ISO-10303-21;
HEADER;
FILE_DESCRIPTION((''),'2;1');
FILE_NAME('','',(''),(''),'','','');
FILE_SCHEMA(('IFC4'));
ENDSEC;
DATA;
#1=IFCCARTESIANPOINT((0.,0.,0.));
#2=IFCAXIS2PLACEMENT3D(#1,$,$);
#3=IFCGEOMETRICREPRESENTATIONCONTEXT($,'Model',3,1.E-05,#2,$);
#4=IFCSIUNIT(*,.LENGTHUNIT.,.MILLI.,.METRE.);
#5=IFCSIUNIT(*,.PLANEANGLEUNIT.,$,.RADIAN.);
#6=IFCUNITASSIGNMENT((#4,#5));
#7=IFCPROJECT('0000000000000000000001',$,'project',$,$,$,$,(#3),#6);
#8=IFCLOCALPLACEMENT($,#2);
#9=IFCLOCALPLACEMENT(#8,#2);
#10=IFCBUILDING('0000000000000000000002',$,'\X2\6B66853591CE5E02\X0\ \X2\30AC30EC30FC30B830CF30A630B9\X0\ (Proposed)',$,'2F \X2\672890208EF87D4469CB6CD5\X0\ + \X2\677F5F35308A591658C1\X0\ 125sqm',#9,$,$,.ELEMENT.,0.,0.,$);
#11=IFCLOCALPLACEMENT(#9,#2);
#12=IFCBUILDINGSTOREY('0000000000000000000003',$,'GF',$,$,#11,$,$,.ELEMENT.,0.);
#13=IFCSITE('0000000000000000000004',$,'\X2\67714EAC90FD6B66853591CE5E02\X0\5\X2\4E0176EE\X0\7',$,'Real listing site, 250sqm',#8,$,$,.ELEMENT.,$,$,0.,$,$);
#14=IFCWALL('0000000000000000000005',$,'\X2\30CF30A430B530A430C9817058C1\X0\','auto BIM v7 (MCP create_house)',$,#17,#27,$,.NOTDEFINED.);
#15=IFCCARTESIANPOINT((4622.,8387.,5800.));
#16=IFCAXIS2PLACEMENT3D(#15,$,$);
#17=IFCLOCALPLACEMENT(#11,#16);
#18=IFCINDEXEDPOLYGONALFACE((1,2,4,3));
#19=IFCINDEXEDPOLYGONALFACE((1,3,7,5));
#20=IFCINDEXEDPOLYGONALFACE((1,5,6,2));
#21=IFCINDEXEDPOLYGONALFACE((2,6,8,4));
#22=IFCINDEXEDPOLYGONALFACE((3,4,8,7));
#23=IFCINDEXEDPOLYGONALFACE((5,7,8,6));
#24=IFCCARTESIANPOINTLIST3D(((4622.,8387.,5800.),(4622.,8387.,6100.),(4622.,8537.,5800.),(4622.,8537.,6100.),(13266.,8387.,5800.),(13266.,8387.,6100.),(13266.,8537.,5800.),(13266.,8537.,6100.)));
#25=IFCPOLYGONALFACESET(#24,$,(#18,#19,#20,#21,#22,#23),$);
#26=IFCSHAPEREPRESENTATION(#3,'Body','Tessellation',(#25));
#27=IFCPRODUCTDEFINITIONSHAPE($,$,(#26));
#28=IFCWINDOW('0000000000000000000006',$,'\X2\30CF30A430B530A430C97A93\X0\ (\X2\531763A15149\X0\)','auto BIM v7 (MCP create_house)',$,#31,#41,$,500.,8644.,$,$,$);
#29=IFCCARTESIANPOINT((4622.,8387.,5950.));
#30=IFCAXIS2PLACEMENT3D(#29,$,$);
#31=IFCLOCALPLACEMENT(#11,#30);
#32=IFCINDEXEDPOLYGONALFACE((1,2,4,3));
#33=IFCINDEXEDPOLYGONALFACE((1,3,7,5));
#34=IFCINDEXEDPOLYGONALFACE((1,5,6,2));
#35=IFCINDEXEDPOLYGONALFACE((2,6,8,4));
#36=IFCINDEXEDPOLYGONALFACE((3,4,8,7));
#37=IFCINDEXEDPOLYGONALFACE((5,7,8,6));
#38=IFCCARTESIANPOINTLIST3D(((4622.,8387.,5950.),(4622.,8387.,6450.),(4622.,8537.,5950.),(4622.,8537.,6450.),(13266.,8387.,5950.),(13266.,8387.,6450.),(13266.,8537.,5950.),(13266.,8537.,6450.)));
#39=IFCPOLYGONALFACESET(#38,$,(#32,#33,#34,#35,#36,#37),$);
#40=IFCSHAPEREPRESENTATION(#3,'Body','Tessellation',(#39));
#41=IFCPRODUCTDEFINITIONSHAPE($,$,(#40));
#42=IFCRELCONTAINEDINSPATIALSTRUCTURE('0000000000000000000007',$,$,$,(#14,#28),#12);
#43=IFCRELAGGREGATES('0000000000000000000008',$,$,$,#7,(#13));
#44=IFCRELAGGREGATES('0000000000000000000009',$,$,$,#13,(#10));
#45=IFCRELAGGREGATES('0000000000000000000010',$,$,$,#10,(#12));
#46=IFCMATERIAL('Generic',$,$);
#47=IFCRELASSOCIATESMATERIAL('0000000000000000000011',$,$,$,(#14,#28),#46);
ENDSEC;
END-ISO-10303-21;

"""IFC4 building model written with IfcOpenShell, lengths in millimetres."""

from ifc_helpers import new_model, si_unit, frame, frame_2d, origin, place, context, project, spatial, rectangle, extrude, material, element, fill, save


model = new_model("IFC4")

# Units and contexts
model_context = context("Model", 3, precision=1e-05, world=origin())
ifc_project = project(units=[si_unit("LENGTHUNIT", "METRE", prefix="MILLI"), si_unit("PLANEANGLEUNIT", "RADIAN")], contexts=[model_context])

# Site, building, storey
site_placement = place(None, origin())
site = spatial("IfcSite", under=ifc_project, at=site_placement, Name="東京都武蔵野市5丁目7", ObjectType="Real listing site, 250sqm", CompositionType="ELEMENT", RefElevation=0.0)
building_placement = place(site_placement, origin())
building = spatial("IfcBuilding", under=site, at=building_placement, Name="武蔵野市 ガレージハウス (Proposed)", ObjectType="2F 木造軸組構法 + 板張り外壁 125sqm", CompositionType="ELEMENT", ElevationOfRefHeight=0.0, ElevationOfTerrain=0.0)
storey_placement = place(building_placement, origin())
storey = spatial("IfcBuildingStorey", under=building, at=storey_placement, Name="GF", CompositionType="ELEMENT", Elevation=0.0)

# Shared definitions
ifc_material = material(Name="Generic")

# Wall, opening, window
wall_1_placement = place(storey_placement, frame((4622.0, 8387.0, 5800.0)))
wall_1 = element("IfcWall", 1, at=wall_1_placement, inside=storey, material=ifc_material, Name="ハイサイド腰壁", Description="auto BIM v7 (MCP create_house)", PredefinedType="NOTDEFINED", context=model_context, shape_type="SweptSolid", body=[
    extrude(rectangle(XDim=8644.0, YDim=150.0, at=frame_2d((4322.0, 75.0))), frame((4622.0, 8387.0, 5800.0)), (0.0, 0.0, 1.0), 700.0),
])
opening_1_placement = place(storey_placement, frame((4622.0, 8387.0, 5950.0)))
opening_1 = element("IfcOpeningElement", 2, at=opening_1_placement, cuts=wall_1, PredefinedType="NOTDEFINED", context=model_context, shape_type="SweptSolid", body=[
    extrude(rectangle(XDim=8644.0, YDim=150.0, at=frame_2d((4322.0, 75.0))), frame((4622.0, 8387.0, 5950.0)), (0.0, 0.0, 1.0), 500.0),
])
window_1_placement = place(storey_placement, frame((4622.0, 8387.0, 5950.0)))
window_1 = element("IfcWindow", 3, at=window_1_placement, inside=storey, material=ifc_material, Name="ハイサイド窓 (北採光)", Description="auto BIM v7 (MCP create_house)", OverallHeight=500.0, OverallWidth=8644.0, context=model_context, shape_type="SweptSolid", body=[
    extrude(rectangle(XDim=8644.0, YDim=150.0, at=frame_2d((4322.0, 75.0))), frame((4622.0, 8387.0, 5950.0)), (0.0, 0.0, 1.0), 500.0),
])
fill(opening_1, window_1)

save(model, "model.ifc")
